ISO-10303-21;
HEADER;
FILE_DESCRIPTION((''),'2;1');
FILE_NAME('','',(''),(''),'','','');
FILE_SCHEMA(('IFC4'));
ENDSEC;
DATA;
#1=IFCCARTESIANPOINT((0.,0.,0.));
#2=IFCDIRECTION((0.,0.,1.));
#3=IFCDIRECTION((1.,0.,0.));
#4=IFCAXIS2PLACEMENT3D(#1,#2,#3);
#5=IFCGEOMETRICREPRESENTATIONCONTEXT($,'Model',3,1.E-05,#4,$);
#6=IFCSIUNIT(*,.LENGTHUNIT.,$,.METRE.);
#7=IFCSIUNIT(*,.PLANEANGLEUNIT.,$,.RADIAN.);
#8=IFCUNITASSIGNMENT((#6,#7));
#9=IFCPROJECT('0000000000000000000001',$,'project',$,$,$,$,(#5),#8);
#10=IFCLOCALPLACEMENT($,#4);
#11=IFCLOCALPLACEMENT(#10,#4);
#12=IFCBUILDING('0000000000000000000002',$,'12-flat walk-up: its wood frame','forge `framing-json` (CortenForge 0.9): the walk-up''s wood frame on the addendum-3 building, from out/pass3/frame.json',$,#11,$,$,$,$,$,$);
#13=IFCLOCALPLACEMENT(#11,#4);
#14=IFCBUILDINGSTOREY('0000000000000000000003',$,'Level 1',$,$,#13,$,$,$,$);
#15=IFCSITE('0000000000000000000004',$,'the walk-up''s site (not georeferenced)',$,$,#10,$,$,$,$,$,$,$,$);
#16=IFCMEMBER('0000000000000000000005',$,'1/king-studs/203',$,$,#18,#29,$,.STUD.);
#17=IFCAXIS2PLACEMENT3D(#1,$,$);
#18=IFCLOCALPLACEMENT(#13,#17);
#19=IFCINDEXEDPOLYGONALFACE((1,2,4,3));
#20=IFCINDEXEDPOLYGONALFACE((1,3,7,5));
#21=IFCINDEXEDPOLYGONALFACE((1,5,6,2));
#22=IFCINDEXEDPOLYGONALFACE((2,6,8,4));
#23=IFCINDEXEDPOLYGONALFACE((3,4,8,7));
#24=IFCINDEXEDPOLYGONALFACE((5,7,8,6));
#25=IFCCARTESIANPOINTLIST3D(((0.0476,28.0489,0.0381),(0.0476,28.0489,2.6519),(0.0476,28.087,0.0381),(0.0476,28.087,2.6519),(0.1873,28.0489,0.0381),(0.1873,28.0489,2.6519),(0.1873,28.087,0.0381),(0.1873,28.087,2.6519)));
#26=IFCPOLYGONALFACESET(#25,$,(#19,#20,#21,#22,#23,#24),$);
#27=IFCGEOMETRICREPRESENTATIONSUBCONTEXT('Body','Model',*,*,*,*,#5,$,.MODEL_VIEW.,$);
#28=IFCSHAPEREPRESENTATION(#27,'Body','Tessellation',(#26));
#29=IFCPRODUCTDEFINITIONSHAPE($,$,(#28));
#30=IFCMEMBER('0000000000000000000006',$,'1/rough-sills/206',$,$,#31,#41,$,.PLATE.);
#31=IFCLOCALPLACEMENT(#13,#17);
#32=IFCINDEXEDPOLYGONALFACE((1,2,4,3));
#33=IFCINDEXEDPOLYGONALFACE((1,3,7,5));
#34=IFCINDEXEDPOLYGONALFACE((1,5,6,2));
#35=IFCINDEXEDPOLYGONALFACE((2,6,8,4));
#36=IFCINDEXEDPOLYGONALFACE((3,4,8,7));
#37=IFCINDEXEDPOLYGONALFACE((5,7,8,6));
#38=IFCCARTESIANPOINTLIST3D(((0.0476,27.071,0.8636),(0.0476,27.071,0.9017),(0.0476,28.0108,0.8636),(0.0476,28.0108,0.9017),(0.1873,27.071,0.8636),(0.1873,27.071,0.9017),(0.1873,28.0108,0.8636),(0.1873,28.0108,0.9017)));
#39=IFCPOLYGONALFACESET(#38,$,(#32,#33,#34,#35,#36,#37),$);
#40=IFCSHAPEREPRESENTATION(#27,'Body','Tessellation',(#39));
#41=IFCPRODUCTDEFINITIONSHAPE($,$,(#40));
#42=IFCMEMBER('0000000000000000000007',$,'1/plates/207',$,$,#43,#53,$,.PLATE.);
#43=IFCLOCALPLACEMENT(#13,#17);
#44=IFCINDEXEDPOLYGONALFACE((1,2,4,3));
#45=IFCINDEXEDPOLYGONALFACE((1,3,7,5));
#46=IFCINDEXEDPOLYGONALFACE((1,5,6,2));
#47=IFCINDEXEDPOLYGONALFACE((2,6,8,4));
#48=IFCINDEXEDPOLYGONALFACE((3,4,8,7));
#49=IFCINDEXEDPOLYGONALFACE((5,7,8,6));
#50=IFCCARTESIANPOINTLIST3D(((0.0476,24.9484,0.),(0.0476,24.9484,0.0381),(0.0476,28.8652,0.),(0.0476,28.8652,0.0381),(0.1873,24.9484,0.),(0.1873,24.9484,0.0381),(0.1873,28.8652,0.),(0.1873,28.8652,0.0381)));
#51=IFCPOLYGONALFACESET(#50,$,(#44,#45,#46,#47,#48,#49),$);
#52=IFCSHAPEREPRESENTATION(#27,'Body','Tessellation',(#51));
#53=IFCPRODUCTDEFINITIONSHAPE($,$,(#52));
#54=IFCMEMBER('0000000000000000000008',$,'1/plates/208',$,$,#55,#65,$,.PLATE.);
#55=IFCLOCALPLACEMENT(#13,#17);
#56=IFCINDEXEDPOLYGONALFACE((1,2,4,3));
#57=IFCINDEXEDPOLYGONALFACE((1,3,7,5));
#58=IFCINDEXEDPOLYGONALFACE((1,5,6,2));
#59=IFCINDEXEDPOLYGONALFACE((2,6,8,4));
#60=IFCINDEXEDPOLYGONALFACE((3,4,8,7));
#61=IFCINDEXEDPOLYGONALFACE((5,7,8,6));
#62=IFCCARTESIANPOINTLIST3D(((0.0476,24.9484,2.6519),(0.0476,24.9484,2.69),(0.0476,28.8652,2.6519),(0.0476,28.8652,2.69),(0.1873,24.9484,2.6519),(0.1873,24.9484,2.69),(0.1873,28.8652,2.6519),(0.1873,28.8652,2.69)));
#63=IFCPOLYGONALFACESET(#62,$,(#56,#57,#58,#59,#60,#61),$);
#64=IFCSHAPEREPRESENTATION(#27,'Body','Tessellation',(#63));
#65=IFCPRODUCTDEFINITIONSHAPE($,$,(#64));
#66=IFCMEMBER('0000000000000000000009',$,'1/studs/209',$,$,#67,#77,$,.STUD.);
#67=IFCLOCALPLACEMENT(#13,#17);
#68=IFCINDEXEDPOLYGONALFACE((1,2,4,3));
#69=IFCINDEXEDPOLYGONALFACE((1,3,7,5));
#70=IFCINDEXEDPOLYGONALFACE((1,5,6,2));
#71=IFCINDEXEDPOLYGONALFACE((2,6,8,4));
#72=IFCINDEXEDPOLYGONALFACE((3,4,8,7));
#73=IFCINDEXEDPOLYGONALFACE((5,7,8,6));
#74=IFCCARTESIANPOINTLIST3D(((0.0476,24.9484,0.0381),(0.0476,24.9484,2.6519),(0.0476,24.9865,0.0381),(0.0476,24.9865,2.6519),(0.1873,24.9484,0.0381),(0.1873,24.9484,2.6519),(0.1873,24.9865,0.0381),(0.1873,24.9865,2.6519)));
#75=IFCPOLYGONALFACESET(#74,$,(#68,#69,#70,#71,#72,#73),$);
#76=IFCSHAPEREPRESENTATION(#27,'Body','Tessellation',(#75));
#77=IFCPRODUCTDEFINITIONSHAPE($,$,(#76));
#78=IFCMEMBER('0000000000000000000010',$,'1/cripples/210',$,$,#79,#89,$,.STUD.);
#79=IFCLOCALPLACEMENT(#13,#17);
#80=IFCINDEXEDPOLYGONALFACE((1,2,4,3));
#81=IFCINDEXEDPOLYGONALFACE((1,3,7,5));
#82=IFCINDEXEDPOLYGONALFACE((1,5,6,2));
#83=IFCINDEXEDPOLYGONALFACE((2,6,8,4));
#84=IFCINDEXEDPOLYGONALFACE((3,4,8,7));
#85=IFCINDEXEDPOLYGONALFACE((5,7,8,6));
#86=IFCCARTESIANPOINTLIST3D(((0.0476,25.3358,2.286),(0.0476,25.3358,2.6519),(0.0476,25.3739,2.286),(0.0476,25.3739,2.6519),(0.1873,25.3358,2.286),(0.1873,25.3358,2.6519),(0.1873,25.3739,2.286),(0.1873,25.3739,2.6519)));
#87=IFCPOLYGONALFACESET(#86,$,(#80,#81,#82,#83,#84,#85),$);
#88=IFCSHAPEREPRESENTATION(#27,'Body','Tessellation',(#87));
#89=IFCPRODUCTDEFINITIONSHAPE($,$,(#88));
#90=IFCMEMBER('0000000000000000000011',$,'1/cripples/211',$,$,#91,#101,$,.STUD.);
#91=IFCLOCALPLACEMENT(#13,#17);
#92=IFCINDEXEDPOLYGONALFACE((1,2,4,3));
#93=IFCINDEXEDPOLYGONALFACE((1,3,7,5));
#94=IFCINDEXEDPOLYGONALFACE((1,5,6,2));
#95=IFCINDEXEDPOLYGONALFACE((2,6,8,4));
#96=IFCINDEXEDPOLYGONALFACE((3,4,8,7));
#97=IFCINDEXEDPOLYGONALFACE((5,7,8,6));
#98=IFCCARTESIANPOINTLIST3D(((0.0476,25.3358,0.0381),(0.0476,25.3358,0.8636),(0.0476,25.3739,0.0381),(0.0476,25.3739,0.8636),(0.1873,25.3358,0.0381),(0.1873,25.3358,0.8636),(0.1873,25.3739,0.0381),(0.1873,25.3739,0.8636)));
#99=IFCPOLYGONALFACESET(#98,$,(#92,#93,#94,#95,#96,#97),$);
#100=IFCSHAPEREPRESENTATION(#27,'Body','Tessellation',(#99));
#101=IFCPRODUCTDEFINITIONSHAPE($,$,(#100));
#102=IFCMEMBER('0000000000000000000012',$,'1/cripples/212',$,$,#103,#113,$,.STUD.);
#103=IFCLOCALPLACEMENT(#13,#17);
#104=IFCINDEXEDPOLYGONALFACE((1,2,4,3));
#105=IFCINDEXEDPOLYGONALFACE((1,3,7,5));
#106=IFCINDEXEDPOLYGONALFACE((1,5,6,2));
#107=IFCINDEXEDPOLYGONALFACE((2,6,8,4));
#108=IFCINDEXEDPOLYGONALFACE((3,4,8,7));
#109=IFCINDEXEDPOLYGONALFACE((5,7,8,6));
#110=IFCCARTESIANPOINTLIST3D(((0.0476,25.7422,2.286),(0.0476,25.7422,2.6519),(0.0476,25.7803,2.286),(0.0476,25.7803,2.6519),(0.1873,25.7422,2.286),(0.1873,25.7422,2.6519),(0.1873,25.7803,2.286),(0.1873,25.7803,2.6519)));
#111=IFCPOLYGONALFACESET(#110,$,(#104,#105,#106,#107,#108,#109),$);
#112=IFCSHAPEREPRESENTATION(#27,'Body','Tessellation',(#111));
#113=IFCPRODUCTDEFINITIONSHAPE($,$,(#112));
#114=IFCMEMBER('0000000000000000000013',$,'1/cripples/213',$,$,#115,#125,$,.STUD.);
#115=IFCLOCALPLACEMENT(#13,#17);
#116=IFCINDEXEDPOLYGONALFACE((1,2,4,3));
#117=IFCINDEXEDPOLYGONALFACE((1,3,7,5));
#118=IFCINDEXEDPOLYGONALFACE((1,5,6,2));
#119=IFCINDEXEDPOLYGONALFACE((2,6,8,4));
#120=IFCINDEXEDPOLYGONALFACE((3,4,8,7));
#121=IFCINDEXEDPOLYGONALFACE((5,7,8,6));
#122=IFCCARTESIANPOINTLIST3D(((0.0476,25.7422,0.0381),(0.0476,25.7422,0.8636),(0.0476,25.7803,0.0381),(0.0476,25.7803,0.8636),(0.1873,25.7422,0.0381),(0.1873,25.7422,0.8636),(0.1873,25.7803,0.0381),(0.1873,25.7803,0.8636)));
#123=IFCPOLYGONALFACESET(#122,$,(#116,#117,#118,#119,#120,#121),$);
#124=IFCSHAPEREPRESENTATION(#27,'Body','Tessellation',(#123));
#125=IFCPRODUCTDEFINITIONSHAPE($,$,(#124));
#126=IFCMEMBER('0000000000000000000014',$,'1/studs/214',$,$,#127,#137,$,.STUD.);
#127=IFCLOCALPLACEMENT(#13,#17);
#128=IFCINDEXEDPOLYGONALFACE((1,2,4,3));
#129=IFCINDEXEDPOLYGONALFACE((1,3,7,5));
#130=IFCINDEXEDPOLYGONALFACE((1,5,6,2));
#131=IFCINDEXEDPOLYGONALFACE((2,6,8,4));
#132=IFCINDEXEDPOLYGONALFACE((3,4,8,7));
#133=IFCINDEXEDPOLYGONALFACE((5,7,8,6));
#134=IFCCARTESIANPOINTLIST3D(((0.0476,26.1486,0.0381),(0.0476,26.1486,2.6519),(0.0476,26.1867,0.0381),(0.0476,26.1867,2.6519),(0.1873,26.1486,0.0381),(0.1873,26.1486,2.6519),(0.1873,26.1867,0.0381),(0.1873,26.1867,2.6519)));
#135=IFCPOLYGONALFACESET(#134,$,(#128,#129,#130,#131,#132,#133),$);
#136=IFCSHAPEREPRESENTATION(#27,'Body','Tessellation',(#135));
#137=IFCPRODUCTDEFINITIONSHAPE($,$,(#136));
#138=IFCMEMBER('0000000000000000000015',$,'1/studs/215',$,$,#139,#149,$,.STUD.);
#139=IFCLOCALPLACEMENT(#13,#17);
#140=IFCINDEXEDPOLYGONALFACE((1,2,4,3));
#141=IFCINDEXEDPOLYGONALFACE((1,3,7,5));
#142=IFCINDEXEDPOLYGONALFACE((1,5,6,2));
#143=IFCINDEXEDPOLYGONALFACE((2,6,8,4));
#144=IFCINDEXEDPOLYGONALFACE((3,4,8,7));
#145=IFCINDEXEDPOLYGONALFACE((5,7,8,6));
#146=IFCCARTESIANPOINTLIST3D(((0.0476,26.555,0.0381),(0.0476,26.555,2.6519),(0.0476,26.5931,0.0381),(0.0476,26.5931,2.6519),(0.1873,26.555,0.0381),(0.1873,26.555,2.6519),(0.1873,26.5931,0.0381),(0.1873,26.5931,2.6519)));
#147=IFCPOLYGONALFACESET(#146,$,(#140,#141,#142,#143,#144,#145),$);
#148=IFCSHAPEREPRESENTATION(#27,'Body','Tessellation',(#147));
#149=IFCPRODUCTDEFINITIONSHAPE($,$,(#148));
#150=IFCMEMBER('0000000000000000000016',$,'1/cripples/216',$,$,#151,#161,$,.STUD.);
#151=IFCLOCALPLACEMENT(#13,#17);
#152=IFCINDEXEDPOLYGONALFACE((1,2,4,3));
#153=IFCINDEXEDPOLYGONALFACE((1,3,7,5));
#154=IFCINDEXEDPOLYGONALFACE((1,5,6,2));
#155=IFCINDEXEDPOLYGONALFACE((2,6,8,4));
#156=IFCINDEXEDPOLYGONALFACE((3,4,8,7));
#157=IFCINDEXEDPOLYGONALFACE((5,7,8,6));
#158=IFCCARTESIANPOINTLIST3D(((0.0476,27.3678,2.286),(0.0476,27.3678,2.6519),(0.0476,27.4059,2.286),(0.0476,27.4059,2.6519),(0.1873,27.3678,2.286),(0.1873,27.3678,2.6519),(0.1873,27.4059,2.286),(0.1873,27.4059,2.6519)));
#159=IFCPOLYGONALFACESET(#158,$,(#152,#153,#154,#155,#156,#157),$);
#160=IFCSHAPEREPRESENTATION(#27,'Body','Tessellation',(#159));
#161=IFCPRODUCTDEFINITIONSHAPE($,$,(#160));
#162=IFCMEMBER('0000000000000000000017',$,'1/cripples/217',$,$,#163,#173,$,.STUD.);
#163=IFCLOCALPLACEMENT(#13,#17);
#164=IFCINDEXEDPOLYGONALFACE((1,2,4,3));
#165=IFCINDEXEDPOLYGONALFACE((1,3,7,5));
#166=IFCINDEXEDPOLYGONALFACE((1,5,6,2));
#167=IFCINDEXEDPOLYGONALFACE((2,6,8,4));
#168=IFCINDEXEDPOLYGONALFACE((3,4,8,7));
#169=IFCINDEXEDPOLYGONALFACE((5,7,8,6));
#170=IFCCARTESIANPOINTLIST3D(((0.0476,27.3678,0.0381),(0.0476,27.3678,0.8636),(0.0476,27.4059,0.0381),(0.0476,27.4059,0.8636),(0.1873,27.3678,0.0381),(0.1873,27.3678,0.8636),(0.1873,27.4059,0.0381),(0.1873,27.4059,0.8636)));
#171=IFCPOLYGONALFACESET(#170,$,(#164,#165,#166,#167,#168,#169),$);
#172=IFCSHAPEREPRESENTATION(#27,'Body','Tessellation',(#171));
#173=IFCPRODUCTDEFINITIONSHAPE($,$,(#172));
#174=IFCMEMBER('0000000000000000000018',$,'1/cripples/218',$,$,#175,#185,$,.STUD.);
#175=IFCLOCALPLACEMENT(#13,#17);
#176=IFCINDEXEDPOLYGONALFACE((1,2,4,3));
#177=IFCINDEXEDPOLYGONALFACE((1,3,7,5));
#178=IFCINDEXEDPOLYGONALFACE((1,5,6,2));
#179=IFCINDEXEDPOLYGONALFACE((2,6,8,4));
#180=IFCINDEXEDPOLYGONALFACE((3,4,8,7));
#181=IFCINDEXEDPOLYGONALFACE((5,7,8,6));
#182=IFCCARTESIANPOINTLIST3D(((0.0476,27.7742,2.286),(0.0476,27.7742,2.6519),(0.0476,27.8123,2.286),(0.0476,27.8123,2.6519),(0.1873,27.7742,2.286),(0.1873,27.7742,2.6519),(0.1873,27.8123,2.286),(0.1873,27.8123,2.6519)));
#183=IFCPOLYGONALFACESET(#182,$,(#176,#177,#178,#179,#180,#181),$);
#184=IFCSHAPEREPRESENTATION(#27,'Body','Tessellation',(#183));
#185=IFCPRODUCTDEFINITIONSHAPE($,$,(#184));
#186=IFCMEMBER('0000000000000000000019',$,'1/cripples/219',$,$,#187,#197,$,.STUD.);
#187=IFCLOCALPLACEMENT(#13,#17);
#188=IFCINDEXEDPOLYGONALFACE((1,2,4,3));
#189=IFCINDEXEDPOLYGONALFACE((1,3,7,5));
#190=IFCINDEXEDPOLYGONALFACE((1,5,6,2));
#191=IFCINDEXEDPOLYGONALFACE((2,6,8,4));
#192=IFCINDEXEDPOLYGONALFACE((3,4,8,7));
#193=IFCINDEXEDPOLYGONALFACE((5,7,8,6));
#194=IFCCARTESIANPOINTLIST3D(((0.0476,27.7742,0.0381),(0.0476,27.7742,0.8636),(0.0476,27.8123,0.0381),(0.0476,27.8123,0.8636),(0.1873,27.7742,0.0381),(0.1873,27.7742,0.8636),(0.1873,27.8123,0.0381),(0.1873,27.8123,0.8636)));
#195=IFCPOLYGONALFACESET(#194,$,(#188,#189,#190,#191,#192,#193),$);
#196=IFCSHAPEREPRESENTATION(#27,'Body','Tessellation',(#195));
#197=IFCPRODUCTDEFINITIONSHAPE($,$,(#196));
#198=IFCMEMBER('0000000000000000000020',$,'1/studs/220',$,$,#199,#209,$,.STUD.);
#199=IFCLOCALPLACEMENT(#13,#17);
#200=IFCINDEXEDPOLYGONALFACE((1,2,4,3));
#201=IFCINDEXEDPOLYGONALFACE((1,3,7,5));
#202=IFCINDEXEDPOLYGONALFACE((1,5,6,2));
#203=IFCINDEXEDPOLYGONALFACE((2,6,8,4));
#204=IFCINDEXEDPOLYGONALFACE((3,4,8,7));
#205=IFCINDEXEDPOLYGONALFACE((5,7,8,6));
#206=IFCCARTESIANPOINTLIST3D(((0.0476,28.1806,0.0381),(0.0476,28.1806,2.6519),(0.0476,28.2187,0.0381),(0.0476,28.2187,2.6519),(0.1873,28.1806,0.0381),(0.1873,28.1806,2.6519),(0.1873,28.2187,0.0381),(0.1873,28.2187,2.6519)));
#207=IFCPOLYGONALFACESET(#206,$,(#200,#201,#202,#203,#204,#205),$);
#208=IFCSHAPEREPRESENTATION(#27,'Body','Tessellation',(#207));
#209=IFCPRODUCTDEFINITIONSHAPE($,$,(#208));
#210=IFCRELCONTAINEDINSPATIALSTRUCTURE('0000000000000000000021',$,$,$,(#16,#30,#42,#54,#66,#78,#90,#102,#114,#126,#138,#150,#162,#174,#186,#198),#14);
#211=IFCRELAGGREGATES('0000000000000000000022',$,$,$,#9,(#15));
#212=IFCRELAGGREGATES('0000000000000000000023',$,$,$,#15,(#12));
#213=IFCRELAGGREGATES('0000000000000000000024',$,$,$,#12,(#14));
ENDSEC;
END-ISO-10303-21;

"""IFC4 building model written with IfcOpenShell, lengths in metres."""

from ifc_helpers import new_model, si_unit, frame, frame_2d, origin, origin_with_axes, place, context, subcontext, project, spatial, rectangle, extrude, element, save


model = new_model("IFC4")

# Units and contexts
model_context = context("Model", 3, precision=1e-05, world=origin_with_axes())
body_context = subcontext(model_context, "Body", "Model", "MODEL_VIEW")
ifc_project = project(units=[si_unit("LENGTHUNIT", "METRE"), si_unit("PLANEANGLEUNIT", "RADIAN")], contexts=[model_context])

# Site, building, storey
site_placement = place(None, origin_with_axes())
site = spatial("IfcSite", under=ifc_project, at=site_placement, Name="the walk-up's site (not georeferenced)")
building_placement = place(site_placement, origin_with_axes())
building = spatial("IfcBuilding", under=site, at=building_placement, Name="12-flat walk-up: its wood frame", Description="forge `framing-json` (CortenForge 0.9): the walk-up's wood frame on the addendum-3 building, from out/pass3/frame.json")
storey_placement = place(building_placement, origin_with_axes())
storey = spatial("IfcBuildingStorey", under=building, at=storey_placement, Name="Level 1")

# Members
member_1_placement = place(storey_placement, frame((0.0476, 28.0489, 0.0381), z_axis=(0.0, 0.0, 1.0), x_axis=(1.0, 0.0, 0.0)))
element("IfcMember", 1, at=member_1_placement, inside=storey, Name="1/king-studs/203", PredefinedType="STUD", context=body_context, shape_type="SweptSolid", body=[
    extrude(rectangle(XDim=0.1397, YDim=0.0381, at=frame_2d((0.0698, 0.0191))), origin(), (0.0, 0.0, 1.0), 2.6138),
])
member_2_placement = place(storey_placement, frame((0.0476, 27.071, 0.8636), z_axis=(0.0, 0.0, 1.0), x_axis=(1.0, 0.0, 0.0)))
element("IfcMember", 2, at=member_2_placement, inside=storey, Name="1/rough-sills/206", PredefinedType="PLATE", context=body_context, shape_type="SweptSolid", body=[
    extrude(rectangle(XDim=0.1397, YDim=0.9398, at=frame_2d((0.0698, 0.4699))), origin(), (0.0, 0.0, 1.0), 0.0381),
])
member_3_placement = place(storey_placement, frame((0.0476, 24.9484, 0.0), z_axis=(0.0, 0.0, 1.0), x_axis=(1.0, 0.0, 0.0)))
element("IfcMember", 3, at=member_3_placement, inside=storey, Name="1/plates/207", PredefinedType="PLATE", context=body_context, shape_type="SweptSolid", body=[
    extrude(rectangle(XDim=0.1397, YDim=3.9168, at=frame_2d((0.0698, 1.9584))), origin(), (0.0, 0.0, 1.0), 0.0381),
])
member_4_placement = place(storey_placement, frame((0.0476, 24.9484, 2.6519), z_axis=(0.0, 0.0, 1.0), x_axis=(1.0, 0.0, 0.0)))
element("IfcMember", 4, at=member_4_placement, inside=storey, Name="1/plates/208", PredefinedType="PLATE", context=body_context, shape_type="SweptSolid", body=[
    extrude(rectangle(XDim=0.1397, YDim=3.9168, at=frame_2d((0.0698, 1.9584))), origin(), (0.0, 0.0, 1.0), 0.0381),
])
member_5_placement = place(storey_placement, frame((0.0476, 24.9484, 0.0381), z_axis=(0.0, 0.0, 1.0), x_axis=(1.0, 0.0, 0.0)))
element("IfcMember", 5, at=member_5_placement, inside=storey, Name="1/studs/209", PredefinedType="STUD", context=body_context, shape_type="SweptSolid", body=[
    extrude(rectangle(XDim=0.1397, YDim=0.0381, at=frame_2d((0.0698, 0.0191))), origin(), (0.0, 0.0, 1.0), 2.6138),
])
member_6_placement = place(storey_placement, frame((0.0476, 25.3358, 2.286), z_axis=(0.0, 0.0, 1.0), x_axis=(1.0, 0.0, 0.0)))
element("IfcMember", 6, at=member_6_placement, inside=storey, Name="1/cripples/210", PredefinedType="STUD", context=body_context, shape_type="SweptSolid", body=[
    extrude(rectangle(XDim=0.1397, YDim=0.0381, at=frame_2d((0.0698, 0.0191))), origin(), (0.0, 0.0, 1.0), 0.3659),
])
member_7_placement = place(storey_placement, frame((0.0476, 25.3358, 0.0381), z_axis=(0.0, 0.0, 1.0), x_axis=(1.0, 0.0, 0.0)))
element("IfcMember", 7, at=member_7_placement, inside=storey, Name="1/cripples/211", PredefinedType="STUD", context=body_context, shape_type="SweptSolid", body=[
    extrude(rectangle(XDim=0.1397, YDim=0.0381, at=frame_2d((0.0698, 0.0191))), origin(), (0.0, 0.0, 1.0), 0.8255),
])
member_8_placement = place(storey_placement, frame((0.0476, 25.7422, 2.286), z_axis=(0.0, 0.0, 1.0), x_axis=(1.0, 0.0, 0.0)))
element("IfcMember", 8, at=member_8_placement, inside=storey, Name="1/cripples/212", PredefinedType="STUD", context=body_context, shape_type="SweptSolid", body=[
    extrude(rectangle(XDim=0.1397, YDim=0.0381, at=frame_2d((0.0698, 0.0191))), origin(), (0.0, 0.0, 1.0), 0.3659),
])
member_9_placement = place(storey_placement, frame((0.0476, 25.7422, 0.0381), z_axis=(0.0, 0.0, 1.0), x_axis=(1.0, 0.0, 0.0)))
element("IfcMember", 9, at=member_9_placement, inside=storey, Name="1/cripples/213", PredefinedType="STUD", context=body_context, shape_type="SweptSolid", body=[
    extrude(rectangle(XDim=0.1397, YDim=0.0381, at=frame_2d((0.0698, 0.0191))), origin(), (0.0, 0.0, 1.0), 0.8255),
])
for number, where, z_axis, x_axis, name in (
    (10, (0.0476, 26.1486, 0.0381), (0.0, 0.0, 1.0), (1.0, 0.0, 0.0), "1/studs/214"),
    (11, (0.0476, 26.555, 0.0381), (0.0, 0.0, 1.0), (1.0, 0.0, 0.0), "1/studs/215"),
):
    element("IfcMember", number, at=place(storey_placement, frame(where, z_axis=z_axis, x_axis=x_axis)), inside=storey, Name=name, PredefinedType="STUD", context=body_context, shape_type="SweptSolid", body=[
        extrude(rectangle(XDim=0.1397, YDim=0.0381, at=frame_2d((0.0698, 0.0191))), origin(), (0.0, 0.0, 1.0), 2.6138),
    ])
member_10_placement = place(storey_placement, frame((0.0476, 27.3678, 2.286), z_axis=(0.0, 0.0, 1.0), x_axis=(1.0, 0.0, 0.0)))
element("IfcMember", 12, at=member_10_placement, inside=storey, Name="1/cripples/216", PredefinedType="STUD", context=body_context, shape_type="SweptSolid", body=[
    extrude(rectangle(XDim=0.1397, YDim=0.0381, at=frame_2d((0.0698, 0.0191))), origin(), (0.0, 0.0, 1.0), 0.3659),
])
member_11_placement = place(storey_placement, frame((0.0476, 27.3678, 0.0381), z_axis=(0.0, 0.0, 1.0), x_axis=(1.0, 0.0, 0.0)))
element("IfcMember", 13, at=member_11_placement, inside=storey, Name="1/cripples/217", PredefinedType="STUD", context=body_context, shape_type="SweptSolid", body=[
    extrude(rectangle(XDim=0.1397, YDim=0.0381, at=frame_2d((0.0698, 0.0191))), origin(), (0.0, 0.0, 1.0), 0.8255),
])
member_12_placement = place(storey_placement, frame((0.0476, 27.7742, 2.286), z_axis=(0.0, 0.0, 1.0), x_axis=(1.0, 0.0, 0.0)))
element("IfcMember", 14, at=member_12_placement, inside=storey, Name="1/cripples/218", PredefinedType="STUD", context=body_context, shape_type="SweptSolid", body=[
    extrude(rectangle(XDim=0.1397, YDim=0.0381, at=frame_2d((0.0698, 0.0191))), origin(), (0.0, 0.0, 1.0), 0.3659),
])
member_13_placement = place(storey_placement, frame((0.0476, 27.7742, 0.0381), z_axis=(0.0, 0.0, 1.0), x_axis=(1.0, 0.0, 0.0)))
element("IfcMember", 15, at=member_13_placement, inside=storey, Name="1/cripples/219", PredefinedType="STUD", context=body_context, shape_type="SweptSolid", body=[
    extrude(rectangle(XDim=0.1397, YDim=0.0381, at=frame_2d((0.0698, 0.0191))), origin(), (0.0, 0.0, 1.0), 0.8255),
])
member_14_placement = place(storey_placement, frame((0.0476, 28.1806, 0.0381), z_axis=(0.0, 0.0, 1.0), x_axis=(1.0, 0.0, 0.0)))
element("IfcMember", 16, at=member_14_placement, inside=storey, Name="1/studs/220", PredefinedType="STUD", context=body_context, shape_type="SweptSolid", body=[
    extrude(rectangle(XDim=0.1397, YDim=0.0381, at=frame_2d((0.0698, 0.0191))), origin(), (0.0, 0.0, 1.0), 2.6138),
])

save(model, "model.ifc")
